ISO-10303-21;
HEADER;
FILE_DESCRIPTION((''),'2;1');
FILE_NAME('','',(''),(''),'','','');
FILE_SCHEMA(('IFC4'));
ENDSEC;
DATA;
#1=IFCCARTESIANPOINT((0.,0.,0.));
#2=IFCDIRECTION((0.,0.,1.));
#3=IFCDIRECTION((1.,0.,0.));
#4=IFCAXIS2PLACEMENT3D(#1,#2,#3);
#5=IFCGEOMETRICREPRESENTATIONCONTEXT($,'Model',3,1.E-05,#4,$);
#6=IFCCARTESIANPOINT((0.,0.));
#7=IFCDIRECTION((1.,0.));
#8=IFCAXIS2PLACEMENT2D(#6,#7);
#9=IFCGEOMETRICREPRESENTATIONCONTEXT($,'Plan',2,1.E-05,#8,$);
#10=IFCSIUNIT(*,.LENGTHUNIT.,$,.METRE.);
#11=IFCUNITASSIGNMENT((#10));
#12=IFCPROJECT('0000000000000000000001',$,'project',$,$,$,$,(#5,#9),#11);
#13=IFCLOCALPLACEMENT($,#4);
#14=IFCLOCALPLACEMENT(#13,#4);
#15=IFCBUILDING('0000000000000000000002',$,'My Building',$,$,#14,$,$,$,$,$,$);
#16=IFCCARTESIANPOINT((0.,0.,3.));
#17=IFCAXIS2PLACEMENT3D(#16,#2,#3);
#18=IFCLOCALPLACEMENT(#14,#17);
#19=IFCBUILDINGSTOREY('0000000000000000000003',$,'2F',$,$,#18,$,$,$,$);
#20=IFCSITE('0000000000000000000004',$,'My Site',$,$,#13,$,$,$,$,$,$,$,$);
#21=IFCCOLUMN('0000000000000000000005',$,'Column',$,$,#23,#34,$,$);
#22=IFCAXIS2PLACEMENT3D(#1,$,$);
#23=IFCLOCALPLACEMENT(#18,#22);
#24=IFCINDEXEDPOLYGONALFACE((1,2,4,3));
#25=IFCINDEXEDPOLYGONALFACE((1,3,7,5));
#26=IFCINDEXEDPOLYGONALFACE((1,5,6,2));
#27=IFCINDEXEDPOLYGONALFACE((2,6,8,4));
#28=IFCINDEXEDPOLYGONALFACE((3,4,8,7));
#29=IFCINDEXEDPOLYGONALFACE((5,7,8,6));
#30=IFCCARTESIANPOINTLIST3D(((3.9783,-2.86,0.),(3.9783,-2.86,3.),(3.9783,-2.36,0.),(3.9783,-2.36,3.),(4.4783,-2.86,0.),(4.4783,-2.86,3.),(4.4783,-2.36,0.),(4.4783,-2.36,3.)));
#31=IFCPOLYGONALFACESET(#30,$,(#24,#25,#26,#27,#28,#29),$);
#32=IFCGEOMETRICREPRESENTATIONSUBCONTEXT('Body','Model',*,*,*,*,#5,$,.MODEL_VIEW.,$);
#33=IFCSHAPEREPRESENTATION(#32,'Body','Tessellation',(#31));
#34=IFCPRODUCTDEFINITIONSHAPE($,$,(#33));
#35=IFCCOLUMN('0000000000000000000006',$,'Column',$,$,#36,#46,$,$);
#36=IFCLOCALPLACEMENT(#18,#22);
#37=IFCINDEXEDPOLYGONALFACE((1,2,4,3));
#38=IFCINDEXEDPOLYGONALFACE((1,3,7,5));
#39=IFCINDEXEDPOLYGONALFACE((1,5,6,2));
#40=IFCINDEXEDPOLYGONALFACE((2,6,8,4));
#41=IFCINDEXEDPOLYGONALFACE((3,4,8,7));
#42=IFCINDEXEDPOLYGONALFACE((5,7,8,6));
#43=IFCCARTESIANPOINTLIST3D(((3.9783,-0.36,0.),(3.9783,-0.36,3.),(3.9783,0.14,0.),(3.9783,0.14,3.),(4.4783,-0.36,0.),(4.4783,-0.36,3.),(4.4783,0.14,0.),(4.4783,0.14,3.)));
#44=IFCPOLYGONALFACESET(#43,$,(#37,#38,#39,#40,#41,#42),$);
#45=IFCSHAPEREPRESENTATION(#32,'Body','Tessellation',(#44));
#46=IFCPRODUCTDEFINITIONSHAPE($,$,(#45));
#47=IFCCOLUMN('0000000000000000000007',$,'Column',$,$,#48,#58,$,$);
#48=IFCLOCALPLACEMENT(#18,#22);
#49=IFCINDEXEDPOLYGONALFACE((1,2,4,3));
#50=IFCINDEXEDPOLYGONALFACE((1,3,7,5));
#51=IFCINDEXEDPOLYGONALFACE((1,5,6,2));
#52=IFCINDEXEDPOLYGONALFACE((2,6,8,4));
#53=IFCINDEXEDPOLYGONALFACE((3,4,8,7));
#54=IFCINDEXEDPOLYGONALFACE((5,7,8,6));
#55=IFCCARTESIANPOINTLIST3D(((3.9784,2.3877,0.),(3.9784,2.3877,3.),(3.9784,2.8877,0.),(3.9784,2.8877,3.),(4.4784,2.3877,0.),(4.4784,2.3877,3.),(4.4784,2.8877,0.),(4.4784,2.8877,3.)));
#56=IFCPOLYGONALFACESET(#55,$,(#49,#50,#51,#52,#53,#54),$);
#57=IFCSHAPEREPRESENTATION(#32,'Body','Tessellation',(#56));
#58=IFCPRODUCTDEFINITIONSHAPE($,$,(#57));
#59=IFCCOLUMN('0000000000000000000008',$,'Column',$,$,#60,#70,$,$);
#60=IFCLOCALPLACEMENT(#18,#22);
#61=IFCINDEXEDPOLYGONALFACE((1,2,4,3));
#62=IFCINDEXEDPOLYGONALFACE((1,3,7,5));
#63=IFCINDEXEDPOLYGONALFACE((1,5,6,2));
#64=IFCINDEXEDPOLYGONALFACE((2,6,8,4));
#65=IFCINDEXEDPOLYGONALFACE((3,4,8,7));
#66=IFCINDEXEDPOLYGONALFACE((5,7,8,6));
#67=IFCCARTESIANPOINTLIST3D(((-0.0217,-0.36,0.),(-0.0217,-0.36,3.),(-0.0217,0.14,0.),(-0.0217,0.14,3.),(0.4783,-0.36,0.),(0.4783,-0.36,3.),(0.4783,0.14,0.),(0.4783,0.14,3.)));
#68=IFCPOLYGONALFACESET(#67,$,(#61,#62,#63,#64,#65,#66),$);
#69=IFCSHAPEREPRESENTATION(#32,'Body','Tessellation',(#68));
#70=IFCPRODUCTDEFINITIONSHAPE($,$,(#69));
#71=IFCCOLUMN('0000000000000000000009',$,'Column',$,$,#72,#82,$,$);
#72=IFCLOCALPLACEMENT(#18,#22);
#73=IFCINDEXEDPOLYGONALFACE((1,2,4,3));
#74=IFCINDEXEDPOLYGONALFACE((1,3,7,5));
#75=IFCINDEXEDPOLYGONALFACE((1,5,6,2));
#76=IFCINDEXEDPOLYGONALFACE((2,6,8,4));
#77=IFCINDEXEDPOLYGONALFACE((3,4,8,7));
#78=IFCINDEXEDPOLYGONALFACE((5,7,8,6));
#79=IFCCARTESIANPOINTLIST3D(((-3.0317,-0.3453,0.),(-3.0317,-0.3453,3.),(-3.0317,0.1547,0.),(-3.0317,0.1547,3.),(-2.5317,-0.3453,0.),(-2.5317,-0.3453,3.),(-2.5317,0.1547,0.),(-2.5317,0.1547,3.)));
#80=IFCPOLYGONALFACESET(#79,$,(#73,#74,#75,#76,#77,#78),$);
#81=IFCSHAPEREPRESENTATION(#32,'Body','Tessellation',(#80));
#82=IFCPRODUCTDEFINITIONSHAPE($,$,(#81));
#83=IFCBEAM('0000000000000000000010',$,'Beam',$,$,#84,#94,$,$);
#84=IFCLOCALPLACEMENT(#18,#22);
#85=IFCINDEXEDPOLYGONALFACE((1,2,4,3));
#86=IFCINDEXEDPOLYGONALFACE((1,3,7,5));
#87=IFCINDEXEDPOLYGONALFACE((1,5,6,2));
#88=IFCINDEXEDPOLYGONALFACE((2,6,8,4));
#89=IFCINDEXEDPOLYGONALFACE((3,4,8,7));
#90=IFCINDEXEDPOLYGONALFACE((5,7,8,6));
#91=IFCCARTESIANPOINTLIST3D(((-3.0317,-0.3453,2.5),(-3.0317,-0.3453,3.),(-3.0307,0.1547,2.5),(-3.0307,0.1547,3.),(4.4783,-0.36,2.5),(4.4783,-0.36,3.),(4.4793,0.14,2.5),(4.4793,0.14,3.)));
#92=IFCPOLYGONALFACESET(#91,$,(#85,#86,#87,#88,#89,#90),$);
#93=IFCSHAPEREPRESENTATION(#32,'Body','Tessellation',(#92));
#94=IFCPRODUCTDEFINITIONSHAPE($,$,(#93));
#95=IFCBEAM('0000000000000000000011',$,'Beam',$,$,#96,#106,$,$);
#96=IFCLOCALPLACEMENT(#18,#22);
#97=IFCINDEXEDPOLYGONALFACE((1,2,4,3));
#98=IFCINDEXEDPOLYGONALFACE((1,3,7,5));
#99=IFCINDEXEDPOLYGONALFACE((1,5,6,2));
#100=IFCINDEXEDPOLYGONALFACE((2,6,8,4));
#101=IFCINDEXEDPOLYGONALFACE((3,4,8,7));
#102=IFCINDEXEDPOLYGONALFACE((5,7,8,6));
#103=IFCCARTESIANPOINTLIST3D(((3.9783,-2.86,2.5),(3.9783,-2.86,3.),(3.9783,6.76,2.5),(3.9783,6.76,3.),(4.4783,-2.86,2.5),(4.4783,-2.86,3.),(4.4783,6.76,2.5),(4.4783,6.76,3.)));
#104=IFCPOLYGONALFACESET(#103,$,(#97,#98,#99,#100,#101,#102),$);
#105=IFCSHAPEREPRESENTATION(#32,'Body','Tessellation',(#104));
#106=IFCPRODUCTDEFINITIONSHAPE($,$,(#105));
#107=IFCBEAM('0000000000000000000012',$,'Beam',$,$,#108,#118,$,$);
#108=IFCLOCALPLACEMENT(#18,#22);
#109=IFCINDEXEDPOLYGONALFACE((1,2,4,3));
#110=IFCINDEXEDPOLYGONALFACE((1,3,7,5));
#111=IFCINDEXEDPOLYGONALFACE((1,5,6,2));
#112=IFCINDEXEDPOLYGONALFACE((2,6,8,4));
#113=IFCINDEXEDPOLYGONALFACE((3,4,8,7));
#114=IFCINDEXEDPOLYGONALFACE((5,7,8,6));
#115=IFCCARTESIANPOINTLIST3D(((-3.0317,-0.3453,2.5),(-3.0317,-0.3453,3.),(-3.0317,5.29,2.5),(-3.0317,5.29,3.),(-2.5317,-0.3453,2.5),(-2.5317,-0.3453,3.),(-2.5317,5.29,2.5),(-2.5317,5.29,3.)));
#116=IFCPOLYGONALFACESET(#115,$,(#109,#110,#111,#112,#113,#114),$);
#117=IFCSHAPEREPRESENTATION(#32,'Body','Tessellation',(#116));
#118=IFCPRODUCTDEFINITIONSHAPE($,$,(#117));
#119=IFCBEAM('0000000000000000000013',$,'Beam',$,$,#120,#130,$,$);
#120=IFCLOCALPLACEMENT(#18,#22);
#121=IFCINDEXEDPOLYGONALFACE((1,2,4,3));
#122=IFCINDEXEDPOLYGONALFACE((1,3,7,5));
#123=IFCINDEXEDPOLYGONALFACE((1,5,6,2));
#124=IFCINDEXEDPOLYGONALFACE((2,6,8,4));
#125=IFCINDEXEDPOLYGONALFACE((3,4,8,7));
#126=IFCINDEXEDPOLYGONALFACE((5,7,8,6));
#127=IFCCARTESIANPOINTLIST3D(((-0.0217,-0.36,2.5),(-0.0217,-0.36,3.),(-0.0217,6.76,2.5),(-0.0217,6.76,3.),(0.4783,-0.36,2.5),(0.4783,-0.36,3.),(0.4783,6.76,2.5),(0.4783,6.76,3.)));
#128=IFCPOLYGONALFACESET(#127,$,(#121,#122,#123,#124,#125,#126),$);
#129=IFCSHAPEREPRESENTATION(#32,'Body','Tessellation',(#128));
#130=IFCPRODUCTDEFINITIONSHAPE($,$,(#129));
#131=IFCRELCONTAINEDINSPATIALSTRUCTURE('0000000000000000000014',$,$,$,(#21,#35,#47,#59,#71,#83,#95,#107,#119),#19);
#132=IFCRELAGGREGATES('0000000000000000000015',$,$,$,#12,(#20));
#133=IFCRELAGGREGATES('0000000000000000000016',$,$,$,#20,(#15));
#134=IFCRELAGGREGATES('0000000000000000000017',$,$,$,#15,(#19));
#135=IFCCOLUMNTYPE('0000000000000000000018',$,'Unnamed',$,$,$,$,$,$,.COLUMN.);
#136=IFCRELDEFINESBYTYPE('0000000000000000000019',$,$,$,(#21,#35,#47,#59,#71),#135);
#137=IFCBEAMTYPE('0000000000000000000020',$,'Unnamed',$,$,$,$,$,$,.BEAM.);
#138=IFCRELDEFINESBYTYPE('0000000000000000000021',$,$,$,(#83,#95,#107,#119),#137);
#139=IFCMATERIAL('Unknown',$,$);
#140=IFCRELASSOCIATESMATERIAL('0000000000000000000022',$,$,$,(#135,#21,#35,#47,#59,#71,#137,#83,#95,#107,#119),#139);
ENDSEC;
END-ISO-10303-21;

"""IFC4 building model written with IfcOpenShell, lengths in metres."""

from ifc_helpers import new_model, si_unit, frame, origin_with_axes, origin_2d_with_axis, place, context, subcontext, project, spatial, indexed_curve, outline, extrude, material, material_profile, profile_set, profile_usage, type_object, element, save


model = new_model("IFC4")

# Units and contexts
model_context = context("Model", 3, precision=1e-05, world=origin_with_axes())
plan_context = context("Plan", 2, precision=1e-05, world=origin_2d_with_axis())
body_context_1 = subcontext(model_context, "Body", "Model", "MODEL_VIEW")
ifc_project = project(units=[si_unit("LENGTHUNIT", "METRE")], contexts=[model_context, plan_context])

# Site, building, storey
site_placement = place(None, origin_with_axes())
site = spatial("IfcSite", under=ifc_project, at=site_placement, Name="My Site")
building_placement = place(site_placement, origin_with_axes())
building = spatial("IfcBuilding", under=site, at=building_placement, Name="My Building")
storey_placement = place(building_placement, frame((0.0, 0.0, 3.0), z_axis=(0.0, 0.0, 1.0), x_axis=(1.0, 0.0, 0.0)))
storey = spatial("IfcBuildingStorey", under=building, at=storey_placement, Name="2F")

# Columns
ifc_material = material(Name="Unknown")
ifc_material_profile_1 = material_profile(ifc_material, outline(indexed_curve([(-0.25, -0.25), (0.25, -0.25), (0.25, 0.25), (-0.25, 0.25), (-0.25, -0.25)])))
ifc_profile_set_1 = profile_set([ifc_material_profile_1])
ifc_profile_usage_1 = profile_usage(ifc_profile_set_1, cardinal=3)
column_type = type_object("IfcColumnType", Name="Unnamed", PredefinedType="COLUMN", material=ifc_profile_set_1)
column_1_placement = place(storey_placement, frame((3.9783, -2.86, 0.0), z_axis=(0.0, 0.0, 1.0), x_axis=(1.0, 0.0, 0.0)))
element("IfcColumn", 1, at=column_1_placement, inside=storey, type_object=column_type, material=ifc_profile_usage_1, Name="Column", context=body_context_1, shape_type="SweptSolid", body=[
    extrude(outline(indexed_curve([(-0.25, -0.25), (0.25, -0.25), (0.25, 0.25), (-0.25, 0.25), (-0.25, -0.25)])), frame((0.25, 0.25, 0.0), z_axis=(0.0, 0.0, 1.0), x_axis=(1.0, 0.0, 0.0)), (0.0, 0.0, 1.0), 3.0),
])
ifc_profile_usage_2 = profile_usage(ifc_profile_set_1, cardinal=3)
column_2_placement = place(storey_placement, frame((3.9783, -0.36, 0.0), z_axis=(0.0, 0.0, 1.0), x_axis=(1.0, 0.0, 0.0)))
element("IfcColumn", 2, at=column_2_placement, inside=storey, type_object=column_type, material=ifc_profile_usage_2, Name="Column", context=body_context_1, shape_type="SweptSolid", body=[
    extrude(outline(indexed_curve([(-0.25, -0.25), (0.25, -0.25), (0.25, 0.25), (-0.25, 0.25), (-0.25, -0.25)])), frame((0.25, 0.25, 0.0), z_axis=(0.0, 0.0, 1.0), x_axis=(1.0, 0.0, 0.0)), (0.0, 0.0, 1.0), 3.0),
])
ifc_profile_usage_3 = profile_usage(ifc_profile_set_1, cardinal=3)
column_3_placement = place(storey_placement, frame((3.9784, 2.3877, 0.0), z_axis=(0.0, 0.0, 1.0), x_axis=(1.0, 0.0, 0.0)))
element("IfcColumn", 3, at=column_3_placement, inside=storey, type_object=column_type, material=ifc_profile_usage_3, Name="Column", context=body_context_1, shape_type="SweptSolid", body=[
    extrude(outline(indexed_curve([(-0.25, -0.25), (0.25, -0.25), (0.25, 0.25), (-0.25, 0.25), (-0.25, -0.25)])), frame((0.25, 0.25, 0.0), z_axis=(0.0, 0.0, 1.0), x_axis=(1.0, 0.0, 0.0)), (0.0, 0.0, 1.0), 3.0),
])
ifc_profile_usage_4 = profile_usage(ifc_profile_set_1, cardinal=3)
column_4_placement = place(storey_placement, frame((-0.0217, -0.36, 0.0), z_axis=(0.0, 0.0, 1.0), x_axis=(1.0, 0.0, 0.0)))
element("IfcColumn", 4, at=column_4_placement, inside=storey, type_object=column_type, material=ifc_profile_usage_4, Name="Column", context=body_context_1, shape_type="SweptSolid", body=[
    extrude(outline(indexed_curve([(-0.25, -0.25), (0.25, -0.25), (0.25, 0.25), (-0.25, 0.25), (-0.25, -0.25)])), frame((0.25, 0.25, 0.0), z_axis=(0.0, 0.0, 1.0), x_axis=(1.0, 0.0, 0.0)), (0.0, 0.0, 1.0), 3.0),
])
ifc_profile_usage_5 = profile_usage(ifc_profile_set_1, cardinal=3)
column_5_placement = place(storey_placement, frame((-3.0317, -0.3453, 0.0), z_axis=(0.0, 0.0, 1.0), x_axis=(1.0, 0.0, 0.0)))
element("IfcColumn", 5, at=column_5_placement, inside=storey, type_object=column_type, material=ifc_profile_usage_5, Name="Column", context=body_context_1, shape_type="SweptSolid", body=[
    extrude(outline(indexed_curve([(-0.25, -0.25), (0.25, -0.25), (0.25, 0.25), (-0.25, 0.25), (-0.25, -0.25)])), frame((0.25, 0.25, 0.0), z_axis=(0.0, 0.0, 1.0), x_axis=(1.0, 0.0, 0.0)), (0.0, 0.0, 1.0), 3.0),
])

# Beams
ifc_material_profile_2 = material_profile(ifc_material, outline(indexed_curve([(-0.25, -0.25), (0.25, -0.25), (0.25, 0.25), (-0.25, 0.25), (-0.25, -0.25)])))
ifc_profile_set_2 = profile_set([ifc_material_profile_2])
ifc_profile_usage_6 = profile_usage(ifc_profile_set_2, cardinal=7)
beam_type = type_object("IfcBeamType", Name="Unnamed", PredefinedType="BEAM", material=ifc_profile_set_2)
beam_1_placement = place(storey_placement, frame((4.4783, -0.36, 3.0), z_axis=(-0.999998, 0.001965, 0.0), x_axis=(-0.001965, -0.999998, 0.0)))
element("IfcBeam", 6, at=beam_1_placement, inside=storey, type_object=beam_type, material=ifc_profile_usage_6, Name="Beam", context=body_context_1, shape_type="SweptSolid", body=[
    extrude(outline(indexed_curve([(-0.25, -0.25), (0.25, -0.25), (0.25, 0.25), (-0.25, 0.25), (-0.25, -0.25)])), frame((-0.25, -0.25, 0.0), z_axis=(0.0, 0.0, 1.0), x_axis=(1.0, 0.0, 0.0)), (0.0, 0.0, 1.0), 7.51),
])
ifc_profile_usage_7 = profile_usage(ifc_profile_set_2, cardinal=9)
beam_2_placement = place(storey_placement, frame((4.4783, -2.86, 3.0), z_axis=(0.0, 1.0, 0.0), x_axis=(-1.0, 0.0, 0.0)))
element("IfcBeam", 7, at=beam_2_placement, inside=storey, type_object=beam_type, material=ifc_profile_usage_7, Name="Beam", context=body_context_1, shape_type="SweptSolid", body=[
    extrude(outline(indexed_curve([(-0.25, -0.25), (0.25, -0.25), (0.25, 0.25), (-0.25, 0.25), (-0.25, -0.25)])), frame((0.25, -0.25, 0.0), z_axis=(0.0, 0.0, 1.0), x_axis=(1.0, 0.0, 0.0)), (0.0, 0.0, 1.0), 9.62),
])
ifc_profile_usage_8 = profile_usage(ifc_profile_set_2, cardinal=9)
beam_3_placement = place(storey_placement, frame((-2.5317, -0.3453, 3.0), z_axis=(0.0, 1.0, 0.0), x_axis=(-1.0, 0.0, 0.0)))
element("IfcBeam", 8, at=beam_3_placement, inside=storey, type_object=beam_type, material=ifc_profile_usage_8, Name="Beam", context=body_context_1, shape_type="SweptSolid", body=[
    extrude(outline(indexed_curve([(-0.25, -0.25), (0.25, -0.25), (0.25, 0.25), (-0.25, 0.25), (-0.25, -0.25)])), frame((0.25, -0.25, 0.0), z_axis=(0.0, 0.0, 1.0), x_axis=(1.0, 0.0, 0.0)), (0.0, 0.0, 1.0), 5.6352),
])
ifc_profile_usage_9 = profile_usage(ifc_profile_set_2, cardinal=9)
beam_4_placement = place(storey_placement, frame((0.4783, -0.36, 3.0), z_axis=(0.0, 1.0, 0.0), x_axis=(-1.0, 0.0, 0.0)))
element("IfcBeam", 9, at=beam_4_placement, inside=storey, type_object=beam_type, material=ifc_profile_usage_9, Name="Beam", context=body_context_1, shape_type="SweptSolid", body=[
    extrude(outline(indexed_curve([(-0.25, -0.25), (0.25, -0.25), (0.25, 0.25), (-0.25, 0.25), (-0.25, -0.25)])), frame((0.25, -0.25, 0.0), z_axis=(0.0, 0.0, 1.0), x_axis=(1.0, 0.0, 0.0)), (0.0, 0.0, 1.0), 7.12),
])

save(model, "model.ifc")
